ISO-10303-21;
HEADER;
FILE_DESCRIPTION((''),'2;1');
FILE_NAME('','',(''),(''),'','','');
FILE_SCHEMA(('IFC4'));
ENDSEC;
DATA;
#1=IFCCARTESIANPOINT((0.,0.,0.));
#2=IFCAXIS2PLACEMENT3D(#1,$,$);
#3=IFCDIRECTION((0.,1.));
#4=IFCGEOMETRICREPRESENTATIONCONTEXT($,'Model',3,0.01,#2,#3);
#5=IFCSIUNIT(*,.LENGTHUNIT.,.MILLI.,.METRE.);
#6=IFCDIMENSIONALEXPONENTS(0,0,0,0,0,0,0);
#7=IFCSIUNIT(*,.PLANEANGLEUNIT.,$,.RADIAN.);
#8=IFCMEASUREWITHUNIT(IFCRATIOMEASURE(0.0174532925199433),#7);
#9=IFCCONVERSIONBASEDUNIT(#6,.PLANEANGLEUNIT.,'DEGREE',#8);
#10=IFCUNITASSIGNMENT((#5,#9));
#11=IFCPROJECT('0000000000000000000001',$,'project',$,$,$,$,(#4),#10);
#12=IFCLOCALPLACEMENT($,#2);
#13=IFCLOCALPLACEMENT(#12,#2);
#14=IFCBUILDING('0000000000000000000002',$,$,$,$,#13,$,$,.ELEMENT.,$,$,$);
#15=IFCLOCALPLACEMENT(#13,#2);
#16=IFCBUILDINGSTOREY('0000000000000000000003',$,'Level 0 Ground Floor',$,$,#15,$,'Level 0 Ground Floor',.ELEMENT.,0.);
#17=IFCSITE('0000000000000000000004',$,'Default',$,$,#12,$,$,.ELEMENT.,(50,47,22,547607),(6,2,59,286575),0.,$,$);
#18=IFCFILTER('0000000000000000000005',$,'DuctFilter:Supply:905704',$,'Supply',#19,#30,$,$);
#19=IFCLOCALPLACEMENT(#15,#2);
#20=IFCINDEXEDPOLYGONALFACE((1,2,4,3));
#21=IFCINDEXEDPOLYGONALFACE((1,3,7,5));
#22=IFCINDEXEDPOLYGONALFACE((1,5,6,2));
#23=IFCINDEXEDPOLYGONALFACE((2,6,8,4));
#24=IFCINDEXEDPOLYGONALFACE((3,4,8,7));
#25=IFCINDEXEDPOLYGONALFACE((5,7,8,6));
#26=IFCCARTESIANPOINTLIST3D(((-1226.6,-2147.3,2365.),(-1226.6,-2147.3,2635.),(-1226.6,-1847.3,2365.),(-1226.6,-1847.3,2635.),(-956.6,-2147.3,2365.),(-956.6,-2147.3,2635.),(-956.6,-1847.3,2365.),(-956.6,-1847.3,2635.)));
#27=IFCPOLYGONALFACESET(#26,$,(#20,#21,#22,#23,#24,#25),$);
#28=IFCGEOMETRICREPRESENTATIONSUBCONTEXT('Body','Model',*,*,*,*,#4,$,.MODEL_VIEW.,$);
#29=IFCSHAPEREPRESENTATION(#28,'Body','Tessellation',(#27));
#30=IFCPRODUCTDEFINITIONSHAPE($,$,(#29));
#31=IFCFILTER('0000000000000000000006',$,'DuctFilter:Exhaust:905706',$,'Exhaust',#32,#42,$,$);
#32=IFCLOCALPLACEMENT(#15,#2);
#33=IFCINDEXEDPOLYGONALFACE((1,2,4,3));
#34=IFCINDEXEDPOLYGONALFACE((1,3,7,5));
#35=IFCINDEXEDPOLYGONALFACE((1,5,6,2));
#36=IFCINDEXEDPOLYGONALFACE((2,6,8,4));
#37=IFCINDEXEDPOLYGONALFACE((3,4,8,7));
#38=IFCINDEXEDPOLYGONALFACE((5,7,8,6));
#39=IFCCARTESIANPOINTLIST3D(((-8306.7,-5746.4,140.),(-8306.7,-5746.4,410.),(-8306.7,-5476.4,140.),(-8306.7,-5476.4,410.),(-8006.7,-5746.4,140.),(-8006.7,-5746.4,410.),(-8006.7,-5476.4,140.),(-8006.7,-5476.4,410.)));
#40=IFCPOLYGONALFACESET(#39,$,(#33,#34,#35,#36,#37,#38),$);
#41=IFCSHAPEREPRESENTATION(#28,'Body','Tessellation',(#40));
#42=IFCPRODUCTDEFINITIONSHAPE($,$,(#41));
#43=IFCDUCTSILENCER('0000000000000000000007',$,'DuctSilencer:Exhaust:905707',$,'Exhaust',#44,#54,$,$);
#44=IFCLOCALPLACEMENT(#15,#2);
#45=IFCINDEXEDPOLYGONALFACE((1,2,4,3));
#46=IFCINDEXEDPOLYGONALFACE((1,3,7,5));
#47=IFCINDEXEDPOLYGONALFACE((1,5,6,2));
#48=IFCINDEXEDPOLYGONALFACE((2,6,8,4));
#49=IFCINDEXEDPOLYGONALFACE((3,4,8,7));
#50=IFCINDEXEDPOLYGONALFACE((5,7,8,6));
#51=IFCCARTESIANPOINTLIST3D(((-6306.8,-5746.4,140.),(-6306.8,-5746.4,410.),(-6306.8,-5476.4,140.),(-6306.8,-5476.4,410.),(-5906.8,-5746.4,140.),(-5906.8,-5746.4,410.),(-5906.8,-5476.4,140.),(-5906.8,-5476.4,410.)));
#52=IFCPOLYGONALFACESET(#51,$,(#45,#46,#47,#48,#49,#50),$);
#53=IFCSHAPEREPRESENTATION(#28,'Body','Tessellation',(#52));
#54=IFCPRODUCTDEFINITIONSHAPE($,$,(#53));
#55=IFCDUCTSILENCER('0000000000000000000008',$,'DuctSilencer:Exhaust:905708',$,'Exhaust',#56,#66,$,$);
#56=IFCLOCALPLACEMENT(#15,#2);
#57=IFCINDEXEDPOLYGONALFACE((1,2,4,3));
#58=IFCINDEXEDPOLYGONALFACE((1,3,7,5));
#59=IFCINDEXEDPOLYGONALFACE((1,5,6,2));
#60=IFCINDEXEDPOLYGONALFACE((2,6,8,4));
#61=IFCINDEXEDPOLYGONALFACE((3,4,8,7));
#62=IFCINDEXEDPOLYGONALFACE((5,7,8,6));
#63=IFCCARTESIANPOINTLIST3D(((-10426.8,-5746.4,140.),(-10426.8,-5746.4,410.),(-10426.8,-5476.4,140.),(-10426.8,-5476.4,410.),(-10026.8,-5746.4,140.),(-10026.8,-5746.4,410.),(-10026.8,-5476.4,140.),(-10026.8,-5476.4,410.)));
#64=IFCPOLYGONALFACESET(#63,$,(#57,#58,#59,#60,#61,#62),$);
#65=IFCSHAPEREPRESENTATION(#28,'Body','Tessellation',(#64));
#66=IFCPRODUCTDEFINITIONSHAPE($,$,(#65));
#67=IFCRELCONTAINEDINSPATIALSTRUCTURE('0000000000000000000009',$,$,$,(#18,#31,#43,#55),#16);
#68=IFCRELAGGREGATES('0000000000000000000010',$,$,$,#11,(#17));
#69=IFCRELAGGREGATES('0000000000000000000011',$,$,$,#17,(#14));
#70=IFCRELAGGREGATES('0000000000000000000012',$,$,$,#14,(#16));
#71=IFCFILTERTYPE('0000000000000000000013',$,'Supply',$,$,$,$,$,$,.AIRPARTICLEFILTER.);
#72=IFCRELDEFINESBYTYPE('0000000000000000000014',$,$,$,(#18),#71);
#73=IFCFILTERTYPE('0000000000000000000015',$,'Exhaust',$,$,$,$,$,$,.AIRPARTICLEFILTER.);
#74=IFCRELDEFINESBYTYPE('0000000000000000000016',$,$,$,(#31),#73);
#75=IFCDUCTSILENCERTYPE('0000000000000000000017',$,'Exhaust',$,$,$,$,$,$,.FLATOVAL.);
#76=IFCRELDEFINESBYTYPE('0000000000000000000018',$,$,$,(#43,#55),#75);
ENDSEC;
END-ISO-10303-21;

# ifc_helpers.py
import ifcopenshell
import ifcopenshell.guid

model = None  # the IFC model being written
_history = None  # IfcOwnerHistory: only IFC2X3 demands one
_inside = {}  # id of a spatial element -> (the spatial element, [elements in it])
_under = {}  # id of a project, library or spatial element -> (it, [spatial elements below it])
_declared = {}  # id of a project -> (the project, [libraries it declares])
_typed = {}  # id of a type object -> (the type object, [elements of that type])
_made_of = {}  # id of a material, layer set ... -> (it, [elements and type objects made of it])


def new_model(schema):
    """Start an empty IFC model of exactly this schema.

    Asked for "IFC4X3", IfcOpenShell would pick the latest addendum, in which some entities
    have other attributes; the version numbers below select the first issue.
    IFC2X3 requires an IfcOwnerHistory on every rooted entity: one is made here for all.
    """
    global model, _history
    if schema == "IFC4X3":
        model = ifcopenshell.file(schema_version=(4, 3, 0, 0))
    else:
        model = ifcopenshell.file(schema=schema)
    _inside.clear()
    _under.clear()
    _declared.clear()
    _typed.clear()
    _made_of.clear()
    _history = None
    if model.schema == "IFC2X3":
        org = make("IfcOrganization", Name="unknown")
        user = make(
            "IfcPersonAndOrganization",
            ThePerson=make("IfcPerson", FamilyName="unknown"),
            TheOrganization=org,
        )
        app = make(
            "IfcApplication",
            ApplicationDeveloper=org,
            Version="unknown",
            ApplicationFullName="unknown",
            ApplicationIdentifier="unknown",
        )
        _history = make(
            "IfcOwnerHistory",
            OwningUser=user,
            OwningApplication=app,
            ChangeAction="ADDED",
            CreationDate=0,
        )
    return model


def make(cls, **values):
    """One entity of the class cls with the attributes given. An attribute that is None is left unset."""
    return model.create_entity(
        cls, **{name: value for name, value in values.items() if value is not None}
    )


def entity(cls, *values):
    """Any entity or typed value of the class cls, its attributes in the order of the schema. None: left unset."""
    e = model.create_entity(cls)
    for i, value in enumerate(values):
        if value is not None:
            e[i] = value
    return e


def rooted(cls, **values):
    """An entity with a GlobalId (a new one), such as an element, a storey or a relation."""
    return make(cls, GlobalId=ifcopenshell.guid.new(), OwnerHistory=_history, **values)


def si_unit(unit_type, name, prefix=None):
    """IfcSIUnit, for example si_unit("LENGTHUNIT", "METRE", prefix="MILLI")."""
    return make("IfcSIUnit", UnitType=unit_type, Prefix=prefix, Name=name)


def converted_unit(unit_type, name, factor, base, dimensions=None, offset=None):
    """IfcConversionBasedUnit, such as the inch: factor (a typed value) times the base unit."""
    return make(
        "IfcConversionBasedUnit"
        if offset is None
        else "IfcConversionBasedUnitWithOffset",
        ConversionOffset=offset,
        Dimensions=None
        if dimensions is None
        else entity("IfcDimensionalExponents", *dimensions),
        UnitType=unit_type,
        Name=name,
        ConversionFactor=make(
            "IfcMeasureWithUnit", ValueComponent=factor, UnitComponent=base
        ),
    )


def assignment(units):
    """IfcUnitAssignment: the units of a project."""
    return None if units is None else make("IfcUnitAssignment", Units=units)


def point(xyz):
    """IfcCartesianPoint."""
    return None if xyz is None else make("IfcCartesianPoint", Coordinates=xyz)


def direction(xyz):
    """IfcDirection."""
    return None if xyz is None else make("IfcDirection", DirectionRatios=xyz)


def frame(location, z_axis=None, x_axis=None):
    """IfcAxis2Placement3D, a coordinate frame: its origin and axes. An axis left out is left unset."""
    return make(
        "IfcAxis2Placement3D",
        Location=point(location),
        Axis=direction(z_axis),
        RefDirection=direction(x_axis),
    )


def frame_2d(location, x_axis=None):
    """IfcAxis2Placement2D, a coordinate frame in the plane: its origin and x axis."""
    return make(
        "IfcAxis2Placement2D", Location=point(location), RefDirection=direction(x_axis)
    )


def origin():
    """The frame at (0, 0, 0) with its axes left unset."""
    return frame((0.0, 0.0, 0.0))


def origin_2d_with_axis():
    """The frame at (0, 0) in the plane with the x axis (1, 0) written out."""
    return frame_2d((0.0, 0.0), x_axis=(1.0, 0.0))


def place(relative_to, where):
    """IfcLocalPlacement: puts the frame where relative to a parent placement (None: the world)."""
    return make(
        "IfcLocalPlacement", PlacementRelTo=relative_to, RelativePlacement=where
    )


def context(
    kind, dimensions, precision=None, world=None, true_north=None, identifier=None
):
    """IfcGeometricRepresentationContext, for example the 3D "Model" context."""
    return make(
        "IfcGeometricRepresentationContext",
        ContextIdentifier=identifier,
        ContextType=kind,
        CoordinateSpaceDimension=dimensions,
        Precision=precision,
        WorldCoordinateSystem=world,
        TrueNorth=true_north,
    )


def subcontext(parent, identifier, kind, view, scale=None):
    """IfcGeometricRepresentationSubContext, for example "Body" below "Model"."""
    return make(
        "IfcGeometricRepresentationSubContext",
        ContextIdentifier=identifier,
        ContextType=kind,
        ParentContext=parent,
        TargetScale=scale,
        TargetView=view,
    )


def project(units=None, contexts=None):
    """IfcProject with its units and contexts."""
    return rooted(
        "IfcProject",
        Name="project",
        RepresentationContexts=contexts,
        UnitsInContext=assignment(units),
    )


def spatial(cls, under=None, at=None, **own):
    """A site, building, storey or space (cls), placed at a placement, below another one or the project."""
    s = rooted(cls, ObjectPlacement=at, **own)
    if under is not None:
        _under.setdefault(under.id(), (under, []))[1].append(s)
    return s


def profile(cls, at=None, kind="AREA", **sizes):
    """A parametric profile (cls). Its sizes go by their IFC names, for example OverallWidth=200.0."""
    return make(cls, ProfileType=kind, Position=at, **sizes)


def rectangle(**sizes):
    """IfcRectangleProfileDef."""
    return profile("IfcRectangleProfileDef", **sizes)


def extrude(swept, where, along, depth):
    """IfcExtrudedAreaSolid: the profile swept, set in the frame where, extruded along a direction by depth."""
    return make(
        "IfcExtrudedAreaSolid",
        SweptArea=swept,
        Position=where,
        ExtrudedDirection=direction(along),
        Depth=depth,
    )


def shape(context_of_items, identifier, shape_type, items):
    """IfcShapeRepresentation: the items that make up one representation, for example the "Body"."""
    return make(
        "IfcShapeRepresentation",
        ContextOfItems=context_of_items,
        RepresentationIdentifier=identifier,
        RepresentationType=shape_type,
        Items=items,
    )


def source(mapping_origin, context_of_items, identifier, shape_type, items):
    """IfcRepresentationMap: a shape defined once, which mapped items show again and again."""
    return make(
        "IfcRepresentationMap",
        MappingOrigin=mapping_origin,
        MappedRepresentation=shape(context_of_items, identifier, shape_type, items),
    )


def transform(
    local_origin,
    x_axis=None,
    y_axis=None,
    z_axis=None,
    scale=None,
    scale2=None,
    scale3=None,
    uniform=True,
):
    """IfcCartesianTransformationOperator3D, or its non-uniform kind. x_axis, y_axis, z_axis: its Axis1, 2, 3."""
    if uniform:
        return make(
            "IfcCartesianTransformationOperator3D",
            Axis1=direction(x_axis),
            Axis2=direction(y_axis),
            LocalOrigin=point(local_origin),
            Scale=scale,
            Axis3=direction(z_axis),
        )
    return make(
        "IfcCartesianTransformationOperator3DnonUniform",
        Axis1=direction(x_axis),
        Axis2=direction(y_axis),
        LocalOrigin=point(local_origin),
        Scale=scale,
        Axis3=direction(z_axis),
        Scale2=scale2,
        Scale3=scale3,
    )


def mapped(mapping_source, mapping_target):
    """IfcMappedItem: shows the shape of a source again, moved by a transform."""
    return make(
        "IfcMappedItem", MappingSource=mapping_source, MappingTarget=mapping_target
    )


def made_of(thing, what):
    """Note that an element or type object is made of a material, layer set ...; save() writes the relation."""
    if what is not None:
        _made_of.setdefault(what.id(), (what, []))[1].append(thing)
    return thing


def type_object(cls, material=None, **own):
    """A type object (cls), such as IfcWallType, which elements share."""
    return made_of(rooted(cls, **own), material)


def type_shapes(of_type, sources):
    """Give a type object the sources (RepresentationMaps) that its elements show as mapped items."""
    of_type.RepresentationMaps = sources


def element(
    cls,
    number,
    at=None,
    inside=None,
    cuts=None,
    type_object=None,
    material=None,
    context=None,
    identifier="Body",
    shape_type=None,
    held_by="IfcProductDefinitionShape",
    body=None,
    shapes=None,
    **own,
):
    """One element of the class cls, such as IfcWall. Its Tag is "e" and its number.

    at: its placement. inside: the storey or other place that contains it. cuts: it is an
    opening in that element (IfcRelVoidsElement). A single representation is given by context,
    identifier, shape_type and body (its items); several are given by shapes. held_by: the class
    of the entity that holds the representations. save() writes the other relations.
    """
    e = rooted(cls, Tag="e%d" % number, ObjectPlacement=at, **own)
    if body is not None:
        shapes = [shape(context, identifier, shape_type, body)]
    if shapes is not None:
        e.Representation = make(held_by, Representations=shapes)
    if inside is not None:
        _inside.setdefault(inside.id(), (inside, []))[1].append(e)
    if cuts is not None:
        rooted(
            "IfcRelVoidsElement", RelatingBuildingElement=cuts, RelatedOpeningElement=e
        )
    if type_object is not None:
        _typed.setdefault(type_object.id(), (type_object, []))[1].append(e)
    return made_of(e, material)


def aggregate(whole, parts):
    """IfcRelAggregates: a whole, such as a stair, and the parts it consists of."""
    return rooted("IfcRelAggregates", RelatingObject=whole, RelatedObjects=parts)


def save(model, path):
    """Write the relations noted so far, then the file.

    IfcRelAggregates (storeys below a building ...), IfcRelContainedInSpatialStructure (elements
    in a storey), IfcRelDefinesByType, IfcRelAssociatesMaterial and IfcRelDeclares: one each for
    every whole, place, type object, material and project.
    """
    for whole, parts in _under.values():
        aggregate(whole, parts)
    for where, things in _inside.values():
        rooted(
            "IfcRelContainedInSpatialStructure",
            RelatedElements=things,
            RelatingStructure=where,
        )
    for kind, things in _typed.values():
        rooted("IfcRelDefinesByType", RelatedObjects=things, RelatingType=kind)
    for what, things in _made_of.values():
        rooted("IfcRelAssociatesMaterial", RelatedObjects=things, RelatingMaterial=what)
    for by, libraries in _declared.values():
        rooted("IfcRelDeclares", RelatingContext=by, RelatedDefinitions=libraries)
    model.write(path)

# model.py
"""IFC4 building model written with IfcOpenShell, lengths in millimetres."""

from ifc_helpers import new_model, entity, si_unit, converted_unit, direction, frame, frame_2d, origin, origin_2d_with_axis, place, context, subcontext, project, spatial, rectangle, extrude, source, transform, mapped, type_object, type_shapes, element, save


model = new_model("IFC4")

# Units and contexts
model_context = context("Model", 3, precision=0.01, world=origin(), true_north=direction((0.0, 1.0)))
body_context = subcontext(model_context, "Body", "Model", "MODEL_VIEW")
ifc_project = project(units=[si_unit("LENGTHUNIT", "METRE", prefix="MILLI"), converted_unit("PLANEANGLEUNIT", "DEGREE", entity("IfcRatioMeasure", 0.0174532925199433), si_unit("PLANEANGLEUNIT", "RADIAN"), dimensions=[0, 0, 0, 0, 0, 0, 0])], contexts=[model_context])

# Site, building, storey
site_placement = place(None, origin())
site = spatial("IfcSite", under=ifc_project, at=site_placement, Name="Default", CompositionType="ELEMENT", RefLatitude=(50, 47, 22, 547607), RefLongitude=(6, 2, 59, 286575), RefElevation=0.0)
building_placement = place(site_placement, origin())
building = spatial("IfcBuilding", under=site, at=building_placement, CompositionType="ELEMENT")
storey_placement = place(building_placement, origin())
storey = spatial("IfcBuildingStorey", under=building, at=storey_placement, Name="Level 0 Ground Floor", LongName="Level 0 Ground Floor", CompositionType="ELEMENT", Elevation=0.0)

# Filters
filter_type_1 = type_object("IfcFilterType", Name="Supply", PredefinedType="AIRPARTICLEFILTER")
shared_shape_1 = source(origin(), body_context, "Body", "SweptSolid", [
    extrude(rectangle(XDim=300.0, YDim=270.0, at=frame_2d((0.0, 0.0), x_axis=(1.0, 0.0))), frame((0.0, 0.0, -135.0), z_axis=(0.0, 0.0, 1.0), x_axis=(-1.0, 0.0, 0.0)), (0.0, 0.0, 1.0), 270.0),
])
type_shapes(filter_type_1, [shared_shape_1])
for number, where, z_axis, x_axis, name in (
    (1, (-1091.6, -1997.3, 2500.0), (0.0, 0.0, 1.0), (0.0, 1.0, 0.0), "DuctFilter:Supply:905704"),
):
    element("IfcFilter", number, at=place(storey_placement, frame(where, z_axis=z_axis, x_axis=x_axis)), inside=storey, type_object=filter_type_1, Name=name, ObjectType="Supply", context=body_context, shape_type="MappedRepresentation", body=[
        mapped(shared_shape_1, transform((0.0, 0.0, 0.0), scale=1.0)),
    ])
filter_type_2 = type_object("IfcFilterType", Name="Exhaust", PredefinedType="AIRPARTICLEFILTER")
shared_shape_2 = source(origin(), body_context, "Body", "SweptSolid", [
    extrude(rectangle(XDim=300.0, YDim=270.0, at=frame_2d((0.0, 0.0), x_axis=(1.0, 0.0))), frame((0.0, 0.0, -135.0), z_axis=(0.0, 0.0, 1.0), x_axis=(-1.0, 0.0, 0.0)), (0.0, 0.0, 1.0), 270.0),
])
type_shapes(filter_type_2, [shared_shape_2])
ifc_filter_placement = place(storey_placement, frame((-8156.7, -5611.4, 275.0), z_axis=(0.0, 0.0, 1.0), x_axis=(-1.0, 0.0, 0.0)))
element("IfcFilter", 2, at=ifc_filter_placement, inside=storey, type_object=filter_type_2, Name="DuctFilter:Exhaust:905706", ObjectType="Exhaust", context=body_context, shape_type="MappedRepresentation", body=[
    mapped(shared_shape_2, transform((0.0, 0.0, 0.0), scale=1.0)),
])

# Duct silencers
duct_silencer_type_1 = type_object("IfcDuctSilencerType", Name="Exhaust", PredefinedType="FLATOVAL")
shared_shape_3 = source(origin(), body_context, "Body", "SweptSolid", [
    extrude(rectangle(XDim=400.0, YDim=270.0, at=origin_2d_with_axis()), frame((0.0, 0.0, -135.0), z_axis=(0.0, 0.0, 1.0), x_axis=(-1.0, 0.0, 0.0)), (0.0, 0.0, 1.0), 270.0),
])
type_shapes(duct_silencer_type_1, [shared_shape_3])
duct_silencer_1_placement = place(storey_placement, frame((-6106.8, -5611.4, 275.0)))
element("IfcDuctSilencer", 3, at=duct_silencer_1_placement, inside=storey, type_object=duct_silencer_type_1, Name="DuctSilencer:Exhaust:905707", ObjectType="Exhaust", context=body_context, shape_type="MappedRepresentation", body=[
    mapped(shared_shape_3, transform((0.0, 0.0, 0.0), scale=1.0)),
])
duct_silencer_2_placement = place(storey_placement, frame((-10226.8, -5611.4, 275.0), z_axis=(0.0, 0.0, 1.0), x_axis=(-1.0, 0.0, 0.0)))
element("IfcDuctSilencer", 4, at=duct_silencer_2_placement, inside=storey, type_object=duct_silencer_type_1, Name="DuctSilencer:Exhaust:905708", ObjectType="Exhaust", context=body_context, shape_type="MappedRepresentation", body=[
    mapped(shared_shape_3, transform((0.0, 0.0, 0.0), scale=1.0)),
])

save(model, "model.ifc")
